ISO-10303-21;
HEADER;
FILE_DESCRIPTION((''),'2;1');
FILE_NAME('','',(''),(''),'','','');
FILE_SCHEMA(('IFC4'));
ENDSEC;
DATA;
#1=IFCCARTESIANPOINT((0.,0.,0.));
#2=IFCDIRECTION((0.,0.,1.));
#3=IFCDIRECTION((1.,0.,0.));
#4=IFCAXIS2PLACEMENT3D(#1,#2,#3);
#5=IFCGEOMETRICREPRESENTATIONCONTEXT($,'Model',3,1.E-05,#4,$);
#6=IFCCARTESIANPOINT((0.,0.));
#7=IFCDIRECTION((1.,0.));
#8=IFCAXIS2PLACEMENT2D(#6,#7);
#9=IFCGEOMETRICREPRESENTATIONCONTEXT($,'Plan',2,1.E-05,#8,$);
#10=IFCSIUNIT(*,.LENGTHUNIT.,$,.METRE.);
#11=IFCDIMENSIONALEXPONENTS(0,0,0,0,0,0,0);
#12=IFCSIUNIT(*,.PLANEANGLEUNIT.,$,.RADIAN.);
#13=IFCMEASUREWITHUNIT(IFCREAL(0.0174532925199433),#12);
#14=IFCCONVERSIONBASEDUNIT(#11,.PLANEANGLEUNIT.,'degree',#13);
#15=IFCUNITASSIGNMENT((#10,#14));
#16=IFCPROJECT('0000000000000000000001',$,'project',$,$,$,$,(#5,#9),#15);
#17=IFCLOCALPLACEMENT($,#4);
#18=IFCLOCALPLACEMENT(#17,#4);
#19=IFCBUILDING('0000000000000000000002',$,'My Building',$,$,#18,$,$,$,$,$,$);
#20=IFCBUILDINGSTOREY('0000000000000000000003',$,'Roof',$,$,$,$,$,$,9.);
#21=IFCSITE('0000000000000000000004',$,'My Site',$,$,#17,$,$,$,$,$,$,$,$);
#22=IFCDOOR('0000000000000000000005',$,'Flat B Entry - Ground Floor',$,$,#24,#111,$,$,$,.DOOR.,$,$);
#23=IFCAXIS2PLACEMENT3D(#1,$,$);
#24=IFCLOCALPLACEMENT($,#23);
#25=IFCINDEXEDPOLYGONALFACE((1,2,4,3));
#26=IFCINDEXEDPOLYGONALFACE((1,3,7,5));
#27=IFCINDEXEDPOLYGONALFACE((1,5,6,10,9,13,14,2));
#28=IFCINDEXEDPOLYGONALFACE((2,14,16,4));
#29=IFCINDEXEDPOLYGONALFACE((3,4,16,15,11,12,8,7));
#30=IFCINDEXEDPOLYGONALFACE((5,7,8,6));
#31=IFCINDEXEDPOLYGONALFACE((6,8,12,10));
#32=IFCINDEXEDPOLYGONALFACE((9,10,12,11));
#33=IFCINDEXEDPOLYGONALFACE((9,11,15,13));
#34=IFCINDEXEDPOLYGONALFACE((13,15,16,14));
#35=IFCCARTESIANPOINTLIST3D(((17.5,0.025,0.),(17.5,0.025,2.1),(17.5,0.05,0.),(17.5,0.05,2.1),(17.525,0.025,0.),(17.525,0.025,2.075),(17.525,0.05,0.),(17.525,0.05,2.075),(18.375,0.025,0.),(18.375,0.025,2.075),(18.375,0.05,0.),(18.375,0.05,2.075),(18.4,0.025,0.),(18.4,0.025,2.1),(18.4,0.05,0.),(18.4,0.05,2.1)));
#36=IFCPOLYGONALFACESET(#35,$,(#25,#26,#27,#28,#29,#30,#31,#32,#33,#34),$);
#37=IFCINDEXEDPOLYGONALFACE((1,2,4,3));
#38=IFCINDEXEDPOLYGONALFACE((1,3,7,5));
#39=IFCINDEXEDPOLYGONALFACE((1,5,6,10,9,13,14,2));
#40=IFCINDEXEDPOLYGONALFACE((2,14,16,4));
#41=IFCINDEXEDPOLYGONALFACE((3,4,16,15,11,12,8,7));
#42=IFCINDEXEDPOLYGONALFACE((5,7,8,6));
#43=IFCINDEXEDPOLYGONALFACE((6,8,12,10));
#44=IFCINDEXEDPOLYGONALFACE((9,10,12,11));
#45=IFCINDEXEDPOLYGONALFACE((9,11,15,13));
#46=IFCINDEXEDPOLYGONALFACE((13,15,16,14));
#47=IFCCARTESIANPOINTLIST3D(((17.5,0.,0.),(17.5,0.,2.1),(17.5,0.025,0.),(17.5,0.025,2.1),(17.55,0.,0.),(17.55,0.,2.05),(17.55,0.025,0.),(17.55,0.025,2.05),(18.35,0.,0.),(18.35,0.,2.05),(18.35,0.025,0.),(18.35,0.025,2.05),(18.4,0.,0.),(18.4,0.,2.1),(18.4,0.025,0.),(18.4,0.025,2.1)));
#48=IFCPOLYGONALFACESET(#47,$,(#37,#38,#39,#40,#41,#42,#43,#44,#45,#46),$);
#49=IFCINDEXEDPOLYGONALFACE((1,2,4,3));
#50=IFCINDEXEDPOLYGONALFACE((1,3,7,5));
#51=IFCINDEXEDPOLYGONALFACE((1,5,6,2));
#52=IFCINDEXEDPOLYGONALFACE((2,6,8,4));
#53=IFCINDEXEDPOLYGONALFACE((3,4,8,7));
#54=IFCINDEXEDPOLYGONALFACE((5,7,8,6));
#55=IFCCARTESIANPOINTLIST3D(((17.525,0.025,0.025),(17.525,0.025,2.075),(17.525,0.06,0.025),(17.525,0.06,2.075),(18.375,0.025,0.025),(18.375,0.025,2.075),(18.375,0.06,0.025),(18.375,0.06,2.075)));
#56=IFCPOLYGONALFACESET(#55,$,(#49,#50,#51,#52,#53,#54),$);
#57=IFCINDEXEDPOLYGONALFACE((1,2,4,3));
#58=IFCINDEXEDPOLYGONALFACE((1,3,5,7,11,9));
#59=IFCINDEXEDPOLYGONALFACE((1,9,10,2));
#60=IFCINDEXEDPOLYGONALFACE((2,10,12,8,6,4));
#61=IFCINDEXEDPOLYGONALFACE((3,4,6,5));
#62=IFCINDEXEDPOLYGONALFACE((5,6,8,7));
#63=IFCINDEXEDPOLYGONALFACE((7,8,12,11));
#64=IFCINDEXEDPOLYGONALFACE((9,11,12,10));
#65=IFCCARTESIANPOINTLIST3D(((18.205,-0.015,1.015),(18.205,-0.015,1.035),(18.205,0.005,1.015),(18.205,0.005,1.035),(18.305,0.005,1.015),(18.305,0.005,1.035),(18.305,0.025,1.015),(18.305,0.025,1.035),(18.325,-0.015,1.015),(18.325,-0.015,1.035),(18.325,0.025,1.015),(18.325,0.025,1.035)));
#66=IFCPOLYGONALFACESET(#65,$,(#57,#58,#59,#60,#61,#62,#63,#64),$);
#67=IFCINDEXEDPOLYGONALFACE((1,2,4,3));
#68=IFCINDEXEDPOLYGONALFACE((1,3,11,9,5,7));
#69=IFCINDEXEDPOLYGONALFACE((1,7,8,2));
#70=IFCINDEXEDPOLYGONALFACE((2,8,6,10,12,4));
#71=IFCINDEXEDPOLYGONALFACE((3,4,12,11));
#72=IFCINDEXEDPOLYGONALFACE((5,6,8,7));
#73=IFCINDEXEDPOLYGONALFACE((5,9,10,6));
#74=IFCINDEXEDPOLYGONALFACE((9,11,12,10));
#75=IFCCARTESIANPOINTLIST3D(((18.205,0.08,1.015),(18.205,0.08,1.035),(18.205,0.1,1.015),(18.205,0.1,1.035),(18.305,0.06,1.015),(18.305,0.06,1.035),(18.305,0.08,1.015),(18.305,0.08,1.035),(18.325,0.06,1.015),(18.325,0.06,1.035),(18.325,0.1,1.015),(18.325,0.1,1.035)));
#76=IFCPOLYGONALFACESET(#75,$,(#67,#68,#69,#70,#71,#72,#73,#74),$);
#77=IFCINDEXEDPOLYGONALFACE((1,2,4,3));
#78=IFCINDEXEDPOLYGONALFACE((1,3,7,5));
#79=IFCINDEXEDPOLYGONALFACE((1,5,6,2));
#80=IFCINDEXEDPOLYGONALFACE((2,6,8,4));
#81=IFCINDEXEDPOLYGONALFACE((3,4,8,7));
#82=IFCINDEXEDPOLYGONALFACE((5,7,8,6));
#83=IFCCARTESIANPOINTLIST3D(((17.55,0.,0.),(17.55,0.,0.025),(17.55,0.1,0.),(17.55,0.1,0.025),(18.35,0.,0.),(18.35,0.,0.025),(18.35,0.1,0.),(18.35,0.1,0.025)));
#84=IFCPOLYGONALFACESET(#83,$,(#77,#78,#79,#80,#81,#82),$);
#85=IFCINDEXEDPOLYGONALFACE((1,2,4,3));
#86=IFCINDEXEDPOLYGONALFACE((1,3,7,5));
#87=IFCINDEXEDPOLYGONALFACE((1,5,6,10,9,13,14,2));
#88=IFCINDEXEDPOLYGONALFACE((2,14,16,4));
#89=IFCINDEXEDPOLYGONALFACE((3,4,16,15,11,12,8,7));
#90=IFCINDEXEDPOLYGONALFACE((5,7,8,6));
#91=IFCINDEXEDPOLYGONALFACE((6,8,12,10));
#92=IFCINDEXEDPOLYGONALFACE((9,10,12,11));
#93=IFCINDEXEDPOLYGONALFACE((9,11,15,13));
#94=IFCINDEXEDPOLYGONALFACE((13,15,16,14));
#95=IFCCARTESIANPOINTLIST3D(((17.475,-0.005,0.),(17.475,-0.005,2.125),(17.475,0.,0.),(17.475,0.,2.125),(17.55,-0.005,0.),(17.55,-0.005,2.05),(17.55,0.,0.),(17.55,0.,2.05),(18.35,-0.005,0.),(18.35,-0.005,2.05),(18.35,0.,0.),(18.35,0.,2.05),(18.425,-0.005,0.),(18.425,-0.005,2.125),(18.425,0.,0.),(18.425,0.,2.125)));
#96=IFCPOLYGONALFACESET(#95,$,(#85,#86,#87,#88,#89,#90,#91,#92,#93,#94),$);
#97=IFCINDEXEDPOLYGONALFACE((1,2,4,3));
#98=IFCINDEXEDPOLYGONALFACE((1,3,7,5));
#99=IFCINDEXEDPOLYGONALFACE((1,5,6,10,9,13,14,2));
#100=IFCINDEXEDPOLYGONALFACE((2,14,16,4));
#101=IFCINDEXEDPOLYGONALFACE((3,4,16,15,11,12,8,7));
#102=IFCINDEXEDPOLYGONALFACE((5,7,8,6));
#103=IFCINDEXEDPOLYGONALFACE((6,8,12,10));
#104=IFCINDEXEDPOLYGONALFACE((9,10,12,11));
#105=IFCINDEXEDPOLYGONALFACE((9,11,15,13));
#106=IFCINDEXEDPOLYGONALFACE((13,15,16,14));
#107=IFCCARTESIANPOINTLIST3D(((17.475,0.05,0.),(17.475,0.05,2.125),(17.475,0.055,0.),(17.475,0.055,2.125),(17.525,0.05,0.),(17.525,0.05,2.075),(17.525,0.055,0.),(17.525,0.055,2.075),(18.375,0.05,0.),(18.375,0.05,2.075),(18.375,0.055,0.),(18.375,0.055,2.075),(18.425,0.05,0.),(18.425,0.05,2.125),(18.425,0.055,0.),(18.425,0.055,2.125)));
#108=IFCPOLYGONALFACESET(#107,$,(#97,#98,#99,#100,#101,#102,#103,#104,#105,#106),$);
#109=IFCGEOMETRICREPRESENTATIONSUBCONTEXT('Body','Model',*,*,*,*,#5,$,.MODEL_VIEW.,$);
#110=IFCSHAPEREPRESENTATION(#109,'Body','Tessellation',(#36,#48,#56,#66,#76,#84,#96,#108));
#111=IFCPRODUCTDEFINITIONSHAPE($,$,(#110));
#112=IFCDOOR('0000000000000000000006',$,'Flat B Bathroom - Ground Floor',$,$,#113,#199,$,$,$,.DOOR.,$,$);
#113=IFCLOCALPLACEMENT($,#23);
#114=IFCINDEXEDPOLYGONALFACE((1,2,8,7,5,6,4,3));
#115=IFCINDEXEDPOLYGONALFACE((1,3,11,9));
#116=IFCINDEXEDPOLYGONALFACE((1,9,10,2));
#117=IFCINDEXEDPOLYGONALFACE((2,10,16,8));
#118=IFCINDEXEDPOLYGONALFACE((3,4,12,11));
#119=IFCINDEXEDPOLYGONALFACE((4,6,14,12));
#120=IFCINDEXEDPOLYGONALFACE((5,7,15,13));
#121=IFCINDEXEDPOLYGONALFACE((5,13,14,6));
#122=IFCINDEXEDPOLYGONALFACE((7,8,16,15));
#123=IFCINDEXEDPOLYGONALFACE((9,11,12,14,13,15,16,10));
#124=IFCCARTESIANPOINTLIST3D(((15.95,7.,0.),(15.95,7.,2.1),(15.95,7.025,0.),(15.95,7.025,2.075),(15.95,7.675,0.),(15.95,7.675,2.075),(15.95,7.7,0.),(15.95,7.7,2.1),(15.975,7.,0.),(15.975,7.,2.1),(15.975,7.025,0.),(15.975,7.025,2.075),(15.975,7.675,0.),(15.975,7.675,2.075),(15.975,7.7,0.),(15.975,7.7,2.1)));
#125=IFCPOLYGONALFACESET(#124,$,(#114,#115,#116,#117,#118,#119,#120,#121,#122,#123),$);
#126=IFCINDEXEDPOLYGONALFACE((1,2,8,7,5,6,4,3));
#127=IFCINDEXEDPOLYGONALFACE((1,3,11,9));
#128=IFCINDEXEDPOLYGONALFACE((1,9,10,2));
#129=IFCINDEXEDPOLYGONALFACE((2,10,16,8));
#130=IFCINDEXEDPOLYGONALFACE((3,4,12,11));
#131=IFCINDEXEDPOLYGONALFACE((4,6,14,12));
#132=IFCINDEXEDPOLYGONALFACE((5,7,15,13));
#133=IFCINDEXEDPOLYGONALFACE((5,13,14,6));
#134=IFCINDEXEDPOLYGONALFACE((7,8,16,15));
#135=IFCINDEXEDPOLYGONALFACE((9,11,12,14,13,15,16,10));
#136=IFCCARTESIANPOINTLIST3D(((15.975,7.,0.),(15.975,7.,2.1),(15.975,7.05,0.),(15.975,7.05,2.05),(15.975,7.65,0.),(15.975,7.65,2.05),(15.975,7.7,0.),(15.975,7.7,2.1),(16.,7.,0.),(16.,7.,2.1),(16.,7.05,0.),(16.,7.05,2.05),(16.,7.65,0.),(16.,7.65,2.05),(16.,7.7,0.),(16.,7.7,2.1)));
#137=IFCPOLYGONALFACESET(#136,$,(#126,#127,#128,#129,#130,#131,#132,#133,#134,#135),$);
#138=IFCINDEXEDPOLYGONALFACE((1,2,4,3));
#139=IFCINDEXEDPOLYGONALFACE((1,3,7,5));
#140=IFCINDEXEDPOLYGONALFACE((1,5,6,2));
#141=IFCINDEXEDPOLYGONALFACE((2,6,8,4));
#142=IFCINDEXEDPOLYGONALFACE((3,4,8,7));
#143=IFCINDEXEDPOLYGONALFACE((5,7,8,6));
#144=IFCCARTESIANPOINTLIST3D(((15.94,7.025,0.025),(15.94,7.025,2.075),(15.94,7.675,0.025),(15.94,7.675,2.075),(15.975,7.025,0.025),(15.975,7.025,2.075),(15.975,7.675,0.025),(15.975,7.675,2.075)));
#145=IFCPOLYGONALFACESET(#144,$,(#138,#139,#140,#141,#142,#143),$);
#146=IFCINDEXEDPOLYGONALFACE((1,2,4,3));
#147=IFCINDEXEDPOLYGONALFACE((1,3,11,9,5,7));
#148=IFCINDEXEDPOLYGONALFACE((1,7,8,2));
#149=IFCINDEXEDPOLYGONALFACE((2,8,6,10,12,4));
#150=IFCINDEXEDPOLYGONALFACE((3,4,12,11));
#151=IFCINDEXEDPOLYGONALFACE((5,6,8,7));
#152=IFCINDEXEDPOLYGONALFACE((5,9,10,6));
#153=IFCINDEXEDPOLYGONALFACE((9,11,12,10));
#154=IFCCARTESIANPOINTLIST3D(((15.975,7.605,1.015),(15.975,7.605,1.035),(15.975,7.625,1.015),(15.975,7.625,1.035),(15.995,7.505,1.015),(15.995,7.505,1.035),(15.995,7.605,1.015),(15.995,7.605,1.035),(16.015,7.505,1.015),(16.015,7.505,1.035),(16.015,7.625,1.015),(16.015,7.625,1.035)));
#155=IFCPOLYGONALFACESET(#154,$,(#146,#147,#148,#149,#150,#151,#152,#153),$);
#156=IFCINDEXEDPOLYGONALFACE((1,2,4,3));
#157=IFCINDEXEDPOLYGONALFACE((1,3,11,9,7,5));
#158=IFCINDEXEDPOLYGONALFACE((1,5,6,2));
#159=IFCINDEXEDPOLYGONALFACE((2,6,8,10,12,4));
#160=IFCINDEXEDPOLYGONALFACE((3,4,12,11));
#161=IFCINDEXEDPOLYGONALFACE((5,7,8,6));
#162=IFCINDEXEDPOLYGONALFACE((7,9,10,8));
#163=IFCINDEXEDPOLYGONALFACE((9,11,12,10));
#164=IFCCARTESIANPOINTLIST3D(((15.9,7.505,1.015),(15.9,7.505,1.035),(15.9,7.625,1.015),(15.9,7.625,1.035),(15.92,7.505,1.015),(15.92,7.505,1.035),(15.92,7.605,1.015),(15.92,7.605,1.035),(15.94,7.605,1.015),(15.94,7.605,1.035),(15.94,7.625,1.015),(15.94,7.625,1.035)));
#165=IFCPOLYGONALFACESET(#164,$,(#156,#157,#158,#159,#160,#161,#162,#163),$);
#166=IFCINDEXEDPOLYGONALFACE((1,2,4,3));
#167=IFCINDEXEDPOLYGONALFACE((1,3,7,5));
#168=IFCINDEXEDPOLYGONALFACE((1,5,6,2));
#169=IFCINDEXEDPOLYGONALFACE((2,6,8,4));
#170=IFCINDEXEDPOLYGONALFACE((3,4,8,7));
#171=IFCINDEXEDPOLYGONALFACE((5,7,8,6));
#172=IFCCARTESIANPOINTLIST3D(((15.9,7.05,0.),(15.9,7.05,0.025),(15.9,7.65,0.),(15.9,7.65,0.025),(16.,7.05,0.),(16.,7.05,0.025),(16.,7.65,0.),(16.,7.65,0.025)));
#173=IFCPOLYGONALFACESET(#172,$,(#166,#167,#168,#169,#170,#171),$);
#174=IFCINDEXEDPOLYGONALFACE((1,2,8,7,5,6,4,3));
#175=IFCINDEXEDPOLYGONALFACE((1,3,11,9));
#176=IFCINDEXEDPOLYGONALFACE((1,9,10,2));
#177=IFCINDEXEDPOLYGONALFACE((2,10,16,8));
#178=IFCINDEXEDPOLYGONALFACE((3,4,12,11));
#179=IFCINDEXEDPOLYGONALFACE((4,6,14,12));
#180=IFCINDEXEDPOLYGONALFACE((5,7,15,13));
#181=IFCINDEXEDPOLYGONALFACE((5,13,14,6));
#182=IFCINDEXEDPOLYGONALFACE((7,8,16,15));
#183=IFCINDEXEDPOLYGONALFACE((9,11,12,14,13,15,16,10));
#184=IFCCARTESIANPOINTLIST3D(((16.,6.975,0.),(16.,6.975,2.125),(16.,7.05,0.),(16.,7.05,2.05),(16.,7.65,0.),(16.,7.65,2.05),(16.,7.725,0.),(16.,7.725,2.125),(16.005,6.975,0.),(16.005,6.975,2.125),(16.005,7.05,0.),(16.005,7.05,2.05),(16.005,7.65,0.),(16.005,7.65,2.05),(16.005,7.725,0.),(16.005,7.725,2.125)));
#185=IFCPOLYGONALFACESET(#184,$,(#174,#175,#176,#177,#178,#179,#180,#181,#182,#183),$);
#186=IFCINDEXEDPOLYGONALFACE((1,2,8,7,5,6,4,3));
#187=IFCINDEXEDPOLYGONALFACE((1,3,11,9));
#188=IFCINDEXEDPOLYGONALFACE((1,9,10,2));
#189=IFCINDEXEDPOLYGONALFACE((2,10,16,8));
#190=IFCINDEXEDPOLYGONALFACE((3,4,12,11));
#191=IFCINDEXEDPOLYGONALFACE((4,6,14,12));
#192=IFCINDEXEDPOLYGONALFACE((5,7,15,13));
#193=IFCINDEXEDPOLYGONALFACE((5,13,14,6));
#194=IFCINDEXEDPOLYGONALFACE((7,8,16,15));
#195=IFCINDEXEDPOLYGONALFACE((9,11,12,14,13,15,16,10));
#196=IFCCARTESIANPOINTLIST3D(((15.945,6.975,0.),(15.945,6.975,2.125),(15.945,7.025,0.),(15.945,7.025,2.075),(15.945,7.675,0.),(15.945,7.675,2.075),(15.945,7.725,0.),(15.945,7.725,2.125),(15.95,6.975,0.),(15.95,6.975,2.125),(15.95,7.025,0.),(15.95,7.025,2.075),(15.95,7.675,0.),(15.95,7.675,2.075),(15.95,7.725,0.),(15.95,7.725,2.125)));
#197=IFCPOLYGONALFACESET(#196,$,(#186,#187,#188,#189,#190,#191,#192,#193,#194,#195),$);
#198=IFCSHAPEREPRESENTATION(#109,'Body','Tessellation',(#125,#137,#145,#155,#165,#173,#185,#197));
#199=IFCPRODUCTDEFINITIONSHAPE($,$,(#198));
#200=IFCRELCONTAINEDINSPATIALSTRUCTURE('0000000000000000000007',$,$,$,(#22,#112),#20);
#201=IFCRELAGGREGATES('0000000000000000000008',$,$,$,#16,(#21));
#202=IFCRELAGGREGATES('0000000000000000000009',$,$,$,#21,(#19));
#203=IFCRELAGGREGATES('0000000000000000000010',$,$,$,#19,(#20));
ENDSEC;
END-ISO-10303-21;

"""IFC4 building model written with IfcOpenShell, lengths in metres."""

from ifc_helpers import new_model, entity, si_unit, converted_unit, frame, origin_with_axes, origin_2d_with_axis, place, context, subcontext, project, spatial, line, indexed_curve, outline, extrude, element, save


model = new_model("IFC4")

# Units and contexts
model_context = context("Model", 3, precision=1e-05, world=origin_with_axes())
plan_context = context("Plan", 2, precision=1e-05, world=origin_2d_with_axis())
body_context = subcontext(model_context, "Body", "Model", "MODEL_VIEW")
ifc_project = project(units=[si_unit("LENGTHUNIT", "METRE"), converted_unit("PLANEANGLEUNIT", "degree", entity("IfcReal", 0.0174532925199433), si_unit("PLANEANGLEUNIT", "RADIAN"), dimensions=[0, 0, 0, 0, 0, 0, 0])], contexts=[model_context, plan_context])

# Site, building, storey
site_placement = place(None, origin_with_axes())
site = spatial("IfcSite", under=ifc_project, at=site_placement, Name="My Site")
building_placement = place(site_placement, origin_with_axes())
building = spatial("IfcBuilding", under=site, at=building_placement, Name="My Building")
storey = spatial("IfcBuildingStorey", under=building, Name="Roof", Elevation=9.0)

# Doors
door_1_placement = place(None, frame((17.5, 0.0, 0.0), z_axis=(0.0, 0.0, 1.0), x_axis=(1.0, 0.0, 0.0)))
element("IfcDoor", 1, at=door_1_placement, inside=storey, Name="Flat B Entry - Ground Floor", PredefinedType="DOOR", context=body_context, shape_type="SweptSolid", body=[
    extrude(outline(indexed_curve([(0.0, 0.0), (0.0, 2.1), (0.9, 2.1), (0.9, 0.0), (0.875, 0.0), (0.875, 2.075), (0.025, 2.075), (0.025, 0.0)], segments=[line(1, 2, 3, 4, 5, 6, 7, 8, 1)])), frame((0.0, 0.025, 0.0), z_axis=(0.0, -1.0, 0.0), x_axis=(1.0, 0.0, 0.0)), (0.0, 0.0, -1.0), 0.025),
    extrude(outline(indexed_curve([(0.0, 0.0), (0.0, 2.1), (0.9, 2.1), (0.9, 0.0), (0.85, 0.0), (0.85, 2.05), (0.05, 2.05), (0.05, 0.0)], segments=[line(1, 2, 3, 4, 5, 6, 7, 8, 1)])), frame((0.0, 0.0, 0.0), z_axis=(0.0, -1.0, 0.0), x_axis=(1.0, 0.0, 0.0)), (0.0, 0.0, -1.0), 0.025),
    extrude(outline(indexed_curve([(0.0, 0.0), (0.85, 0.0), (0.85, 0.035), (0.0, 0.035)], segments=[line(1, 2, 3, 4, 1)])), frame((0.025, 0.025, 0.025), z_axis=(0.0, 0.0, 1.0), x_axis=(1.0, 0.0, 0.0)), (0.0, 0.0, 1.0), 2.05),
    extrude(outline(indexed_curve([(0.0, 0.0), (0.0, -0.04), (-0.12, -0.04), (-0.12, -0.02), (-0.02, -0.02), (-0.02, 0.0)], segments=[line(1, 2, 3, 4, 5, 6, 1)])), frame((0.825, 0.025, 1.015), z_axis=(0.0, 0.0, 1.0), x_axis=(1.0, 0.0, 0.0)), (0.0, 0.0, 1.0), 0.02),
    extrude(outline(indexed_curve([(0.0, 0.0), (0.0, 0.04), (-0.12, 0.04), (-0.12, 0.02), (-0.02, 0.02), (-0.02, 0.0)], segments=[line(1, 2, 3, 4, 5, 6, 1)])), frame((0.825, 0.06, 1.015), z_axis=(0.0, 0.0, 1.0), x_axis=(1.0, 0.0, 0.0)), (0.0, 0.0, 1.0), 0.02),
    extrude(outline(indexed_curve([(0.0, 0.0), (0.8, 0.0), (0.8, 0.1), (0.0, 0.1)], segments=[line(1, 2, 3, 4, 1)])), frame((0.05, 0.0, 0.0), z_axis=(0.0, 0.0, 1.0), x_axis=(1.0, 0.0, 0.0)), (0.0, 0.0, 1.0), 0.025),
    extrude(outline(indexed_curve([(0.0, 0.0), (0.0, 2.125), (0.95, 2.125), (0.95, 0.0), (0.875, 0.0), (0.875, 2.05), (0.075, 2.05), (0.075, 0.0)], segments=[line(1, 2, 3, 4, 5, 6, 7, 8, 1)])), frame((-0.025, -0.005, 0.0), z_axis=(0.0, -1.0, 0.0), x_axis=(1.0, 0.0, 0.0)), (0.0, 0.0, -1.0), 0.005),
    extrude(outline(indexed_curve([(0.0, 0.0), (0.0, 2.125), (0.95, 2.125), (0.95, 0.0), (0.9, 0.0), (0.9, 2.075), (0.05, 2.075), (0.05, 0.0)], segments=[line(1, 2, 3, 4, 5, 6, 7, 8, 1)])), frame((-0.025, 0.05, 0.0), z_axis=(0.0, -1.0, 0.0), x_axis=(1.0, 0.0, 0.0)), (0.0, 0.0, -1.0), 0.005),
])
door_2_placement = place(None, frame((16.0, 7.0, 0.0), z_axis=(0.0, 0.0, 1.0), x_axis=(0.0, 1.0, 0.0)))
element("IfcDoor", 2, at=door_2_placement, inside=storey, Name="Flat B Bathroom - Ground Floor", PredefinedType="DOOR", context=body_context, shape_type="SweptSolid", body=[
    extrude(outline(indexed_curve([(0.0, 0.0), (0.0, 2.1), (0.7, 2.1), (0.7, 0.0), (0.675, 0.0), (0.675, 2.075), (0.025, 2.075), (0.025, 0.0)], segments=[line(1, 2, 3, 4, 5, 6, 7, 8, 1)])), frame((0.0, 0.025, 0.0), z_axis=(0.0, -1.0, 0.0), x_axis=(1.0, 0.0, 0.0)), (0.0, 0.0, -1.0), 0.025),
    extrude(outline(indexed_curve([(0.0, 0.0), (0.0, 2.1), (0.7, 2.1), (0.7, 0.0), (0.65, 0.0), (0.65, 2.05), (0.05, 2.05), (0.05, 0.0)], segments=[line(1, 2, 3, 4, 5, 6, 7, 8, 1)])), frame((0.0, 0.0, 0.0), z_axis=(0.0, -1.0, 0.0), x_axis=(1.0, 0.0, 0.0)), (0.0, 0.0, -1.0), 0.025),
    extrude(outline(indexed_curve([(0.0, 0.0), (0.65, 0.0), (0.65, 0.035), (0.0, 0.035)], segments=[line(1, 2, 3, 4, 1)])), frame((0.025, 0.025, 0.025), z_axis=(0.0, 0.0, 1.0), x_axis=(1.0, 0.0, 0.0)), (0.0, 0.0, 1.0), 2.05),
    extrude(outline(indexed_curve([(0.0, 0.0), (0.0, -0.04), (-0.12, -0.04), (-0.12, -0.02), (-0.02, -0.02), (-0.02, 0.0)], segments=[line(1, 2, 3, 4, 5, 6, 1)])), frame((0.625, 0.025, 1.015), z_axis=(0.0, 0.0, 1.0), x_axis=(1.0, 0.0, 0.0)), (0.0, 0.0, 1.0), 0.02),
    extrude(outline(indexed_curve([(0.0, 0.0), (0.0, 0.04), (-0.12, 0.04), (-0.12, 0.02), (-0.02, 0.02), (-0.02, 0.0)], segments=[line(1, 2, 3, 4, 5, 6, 1)])), frame((0.625, 0.06, 1.015), z_axis=(0.0, 0.0, 1.0), x_axis=(1.0, 0.0, 0.0)), (0.0, 0.0, 1.0), 0.02),
    extrude(outline(indexed_curve([(0.0, 0.0), (0.6, 0.0), (0.6, 0.1), (0.0, 0.1)], segments=[line(1, 2, 3, 4, 1)])), frame((0.05, 0.0, 0.0), z_axis=(0.0, 0.0, 1.0), x_axis=(1.0, 0.0, 0.0)), (0.0, 0.0, 1.0), 0.025),
    extrude(outline(indexed_curve([(0.0, 0.0), (0.0, 2.125), (0.75, 2.125), (0.75, 0.0), (0.675, 0.0), (0.675, 2.05), (0.075, 2.05), (0.075, 0.0)], segments=[line(1, 2, 3, 4, 5, 6, 7, 8, 1)])), frame((-0.025, -0.005, 0.0), z_axis=(0.0, -1.0, 0.0), x_axis=(1.0, 0.0, 0.0)), (0.0, 0.0, -1.0), 0.005),
    extrude(outline(indexed_curve([(0.0, 0.0), (0.0, 2.125), (0.75, 2.125), (0.75, 0.0), (0.7, 0.0), (0.7, 2.075), (0.05, 2.075), (0.05, 0.0)], segments=[line(1, 2, 3, 4, 5, 6, 7, 8, 1)])), frame((-0.025, 0.05, 0.0), z_axis=(0.0, -1.0, 0.0), x_axis=(1.0, 0.0, 0.0)), (0.0, 0.0, -1.0), 0.005),
])

save(model, "model.ifc")
